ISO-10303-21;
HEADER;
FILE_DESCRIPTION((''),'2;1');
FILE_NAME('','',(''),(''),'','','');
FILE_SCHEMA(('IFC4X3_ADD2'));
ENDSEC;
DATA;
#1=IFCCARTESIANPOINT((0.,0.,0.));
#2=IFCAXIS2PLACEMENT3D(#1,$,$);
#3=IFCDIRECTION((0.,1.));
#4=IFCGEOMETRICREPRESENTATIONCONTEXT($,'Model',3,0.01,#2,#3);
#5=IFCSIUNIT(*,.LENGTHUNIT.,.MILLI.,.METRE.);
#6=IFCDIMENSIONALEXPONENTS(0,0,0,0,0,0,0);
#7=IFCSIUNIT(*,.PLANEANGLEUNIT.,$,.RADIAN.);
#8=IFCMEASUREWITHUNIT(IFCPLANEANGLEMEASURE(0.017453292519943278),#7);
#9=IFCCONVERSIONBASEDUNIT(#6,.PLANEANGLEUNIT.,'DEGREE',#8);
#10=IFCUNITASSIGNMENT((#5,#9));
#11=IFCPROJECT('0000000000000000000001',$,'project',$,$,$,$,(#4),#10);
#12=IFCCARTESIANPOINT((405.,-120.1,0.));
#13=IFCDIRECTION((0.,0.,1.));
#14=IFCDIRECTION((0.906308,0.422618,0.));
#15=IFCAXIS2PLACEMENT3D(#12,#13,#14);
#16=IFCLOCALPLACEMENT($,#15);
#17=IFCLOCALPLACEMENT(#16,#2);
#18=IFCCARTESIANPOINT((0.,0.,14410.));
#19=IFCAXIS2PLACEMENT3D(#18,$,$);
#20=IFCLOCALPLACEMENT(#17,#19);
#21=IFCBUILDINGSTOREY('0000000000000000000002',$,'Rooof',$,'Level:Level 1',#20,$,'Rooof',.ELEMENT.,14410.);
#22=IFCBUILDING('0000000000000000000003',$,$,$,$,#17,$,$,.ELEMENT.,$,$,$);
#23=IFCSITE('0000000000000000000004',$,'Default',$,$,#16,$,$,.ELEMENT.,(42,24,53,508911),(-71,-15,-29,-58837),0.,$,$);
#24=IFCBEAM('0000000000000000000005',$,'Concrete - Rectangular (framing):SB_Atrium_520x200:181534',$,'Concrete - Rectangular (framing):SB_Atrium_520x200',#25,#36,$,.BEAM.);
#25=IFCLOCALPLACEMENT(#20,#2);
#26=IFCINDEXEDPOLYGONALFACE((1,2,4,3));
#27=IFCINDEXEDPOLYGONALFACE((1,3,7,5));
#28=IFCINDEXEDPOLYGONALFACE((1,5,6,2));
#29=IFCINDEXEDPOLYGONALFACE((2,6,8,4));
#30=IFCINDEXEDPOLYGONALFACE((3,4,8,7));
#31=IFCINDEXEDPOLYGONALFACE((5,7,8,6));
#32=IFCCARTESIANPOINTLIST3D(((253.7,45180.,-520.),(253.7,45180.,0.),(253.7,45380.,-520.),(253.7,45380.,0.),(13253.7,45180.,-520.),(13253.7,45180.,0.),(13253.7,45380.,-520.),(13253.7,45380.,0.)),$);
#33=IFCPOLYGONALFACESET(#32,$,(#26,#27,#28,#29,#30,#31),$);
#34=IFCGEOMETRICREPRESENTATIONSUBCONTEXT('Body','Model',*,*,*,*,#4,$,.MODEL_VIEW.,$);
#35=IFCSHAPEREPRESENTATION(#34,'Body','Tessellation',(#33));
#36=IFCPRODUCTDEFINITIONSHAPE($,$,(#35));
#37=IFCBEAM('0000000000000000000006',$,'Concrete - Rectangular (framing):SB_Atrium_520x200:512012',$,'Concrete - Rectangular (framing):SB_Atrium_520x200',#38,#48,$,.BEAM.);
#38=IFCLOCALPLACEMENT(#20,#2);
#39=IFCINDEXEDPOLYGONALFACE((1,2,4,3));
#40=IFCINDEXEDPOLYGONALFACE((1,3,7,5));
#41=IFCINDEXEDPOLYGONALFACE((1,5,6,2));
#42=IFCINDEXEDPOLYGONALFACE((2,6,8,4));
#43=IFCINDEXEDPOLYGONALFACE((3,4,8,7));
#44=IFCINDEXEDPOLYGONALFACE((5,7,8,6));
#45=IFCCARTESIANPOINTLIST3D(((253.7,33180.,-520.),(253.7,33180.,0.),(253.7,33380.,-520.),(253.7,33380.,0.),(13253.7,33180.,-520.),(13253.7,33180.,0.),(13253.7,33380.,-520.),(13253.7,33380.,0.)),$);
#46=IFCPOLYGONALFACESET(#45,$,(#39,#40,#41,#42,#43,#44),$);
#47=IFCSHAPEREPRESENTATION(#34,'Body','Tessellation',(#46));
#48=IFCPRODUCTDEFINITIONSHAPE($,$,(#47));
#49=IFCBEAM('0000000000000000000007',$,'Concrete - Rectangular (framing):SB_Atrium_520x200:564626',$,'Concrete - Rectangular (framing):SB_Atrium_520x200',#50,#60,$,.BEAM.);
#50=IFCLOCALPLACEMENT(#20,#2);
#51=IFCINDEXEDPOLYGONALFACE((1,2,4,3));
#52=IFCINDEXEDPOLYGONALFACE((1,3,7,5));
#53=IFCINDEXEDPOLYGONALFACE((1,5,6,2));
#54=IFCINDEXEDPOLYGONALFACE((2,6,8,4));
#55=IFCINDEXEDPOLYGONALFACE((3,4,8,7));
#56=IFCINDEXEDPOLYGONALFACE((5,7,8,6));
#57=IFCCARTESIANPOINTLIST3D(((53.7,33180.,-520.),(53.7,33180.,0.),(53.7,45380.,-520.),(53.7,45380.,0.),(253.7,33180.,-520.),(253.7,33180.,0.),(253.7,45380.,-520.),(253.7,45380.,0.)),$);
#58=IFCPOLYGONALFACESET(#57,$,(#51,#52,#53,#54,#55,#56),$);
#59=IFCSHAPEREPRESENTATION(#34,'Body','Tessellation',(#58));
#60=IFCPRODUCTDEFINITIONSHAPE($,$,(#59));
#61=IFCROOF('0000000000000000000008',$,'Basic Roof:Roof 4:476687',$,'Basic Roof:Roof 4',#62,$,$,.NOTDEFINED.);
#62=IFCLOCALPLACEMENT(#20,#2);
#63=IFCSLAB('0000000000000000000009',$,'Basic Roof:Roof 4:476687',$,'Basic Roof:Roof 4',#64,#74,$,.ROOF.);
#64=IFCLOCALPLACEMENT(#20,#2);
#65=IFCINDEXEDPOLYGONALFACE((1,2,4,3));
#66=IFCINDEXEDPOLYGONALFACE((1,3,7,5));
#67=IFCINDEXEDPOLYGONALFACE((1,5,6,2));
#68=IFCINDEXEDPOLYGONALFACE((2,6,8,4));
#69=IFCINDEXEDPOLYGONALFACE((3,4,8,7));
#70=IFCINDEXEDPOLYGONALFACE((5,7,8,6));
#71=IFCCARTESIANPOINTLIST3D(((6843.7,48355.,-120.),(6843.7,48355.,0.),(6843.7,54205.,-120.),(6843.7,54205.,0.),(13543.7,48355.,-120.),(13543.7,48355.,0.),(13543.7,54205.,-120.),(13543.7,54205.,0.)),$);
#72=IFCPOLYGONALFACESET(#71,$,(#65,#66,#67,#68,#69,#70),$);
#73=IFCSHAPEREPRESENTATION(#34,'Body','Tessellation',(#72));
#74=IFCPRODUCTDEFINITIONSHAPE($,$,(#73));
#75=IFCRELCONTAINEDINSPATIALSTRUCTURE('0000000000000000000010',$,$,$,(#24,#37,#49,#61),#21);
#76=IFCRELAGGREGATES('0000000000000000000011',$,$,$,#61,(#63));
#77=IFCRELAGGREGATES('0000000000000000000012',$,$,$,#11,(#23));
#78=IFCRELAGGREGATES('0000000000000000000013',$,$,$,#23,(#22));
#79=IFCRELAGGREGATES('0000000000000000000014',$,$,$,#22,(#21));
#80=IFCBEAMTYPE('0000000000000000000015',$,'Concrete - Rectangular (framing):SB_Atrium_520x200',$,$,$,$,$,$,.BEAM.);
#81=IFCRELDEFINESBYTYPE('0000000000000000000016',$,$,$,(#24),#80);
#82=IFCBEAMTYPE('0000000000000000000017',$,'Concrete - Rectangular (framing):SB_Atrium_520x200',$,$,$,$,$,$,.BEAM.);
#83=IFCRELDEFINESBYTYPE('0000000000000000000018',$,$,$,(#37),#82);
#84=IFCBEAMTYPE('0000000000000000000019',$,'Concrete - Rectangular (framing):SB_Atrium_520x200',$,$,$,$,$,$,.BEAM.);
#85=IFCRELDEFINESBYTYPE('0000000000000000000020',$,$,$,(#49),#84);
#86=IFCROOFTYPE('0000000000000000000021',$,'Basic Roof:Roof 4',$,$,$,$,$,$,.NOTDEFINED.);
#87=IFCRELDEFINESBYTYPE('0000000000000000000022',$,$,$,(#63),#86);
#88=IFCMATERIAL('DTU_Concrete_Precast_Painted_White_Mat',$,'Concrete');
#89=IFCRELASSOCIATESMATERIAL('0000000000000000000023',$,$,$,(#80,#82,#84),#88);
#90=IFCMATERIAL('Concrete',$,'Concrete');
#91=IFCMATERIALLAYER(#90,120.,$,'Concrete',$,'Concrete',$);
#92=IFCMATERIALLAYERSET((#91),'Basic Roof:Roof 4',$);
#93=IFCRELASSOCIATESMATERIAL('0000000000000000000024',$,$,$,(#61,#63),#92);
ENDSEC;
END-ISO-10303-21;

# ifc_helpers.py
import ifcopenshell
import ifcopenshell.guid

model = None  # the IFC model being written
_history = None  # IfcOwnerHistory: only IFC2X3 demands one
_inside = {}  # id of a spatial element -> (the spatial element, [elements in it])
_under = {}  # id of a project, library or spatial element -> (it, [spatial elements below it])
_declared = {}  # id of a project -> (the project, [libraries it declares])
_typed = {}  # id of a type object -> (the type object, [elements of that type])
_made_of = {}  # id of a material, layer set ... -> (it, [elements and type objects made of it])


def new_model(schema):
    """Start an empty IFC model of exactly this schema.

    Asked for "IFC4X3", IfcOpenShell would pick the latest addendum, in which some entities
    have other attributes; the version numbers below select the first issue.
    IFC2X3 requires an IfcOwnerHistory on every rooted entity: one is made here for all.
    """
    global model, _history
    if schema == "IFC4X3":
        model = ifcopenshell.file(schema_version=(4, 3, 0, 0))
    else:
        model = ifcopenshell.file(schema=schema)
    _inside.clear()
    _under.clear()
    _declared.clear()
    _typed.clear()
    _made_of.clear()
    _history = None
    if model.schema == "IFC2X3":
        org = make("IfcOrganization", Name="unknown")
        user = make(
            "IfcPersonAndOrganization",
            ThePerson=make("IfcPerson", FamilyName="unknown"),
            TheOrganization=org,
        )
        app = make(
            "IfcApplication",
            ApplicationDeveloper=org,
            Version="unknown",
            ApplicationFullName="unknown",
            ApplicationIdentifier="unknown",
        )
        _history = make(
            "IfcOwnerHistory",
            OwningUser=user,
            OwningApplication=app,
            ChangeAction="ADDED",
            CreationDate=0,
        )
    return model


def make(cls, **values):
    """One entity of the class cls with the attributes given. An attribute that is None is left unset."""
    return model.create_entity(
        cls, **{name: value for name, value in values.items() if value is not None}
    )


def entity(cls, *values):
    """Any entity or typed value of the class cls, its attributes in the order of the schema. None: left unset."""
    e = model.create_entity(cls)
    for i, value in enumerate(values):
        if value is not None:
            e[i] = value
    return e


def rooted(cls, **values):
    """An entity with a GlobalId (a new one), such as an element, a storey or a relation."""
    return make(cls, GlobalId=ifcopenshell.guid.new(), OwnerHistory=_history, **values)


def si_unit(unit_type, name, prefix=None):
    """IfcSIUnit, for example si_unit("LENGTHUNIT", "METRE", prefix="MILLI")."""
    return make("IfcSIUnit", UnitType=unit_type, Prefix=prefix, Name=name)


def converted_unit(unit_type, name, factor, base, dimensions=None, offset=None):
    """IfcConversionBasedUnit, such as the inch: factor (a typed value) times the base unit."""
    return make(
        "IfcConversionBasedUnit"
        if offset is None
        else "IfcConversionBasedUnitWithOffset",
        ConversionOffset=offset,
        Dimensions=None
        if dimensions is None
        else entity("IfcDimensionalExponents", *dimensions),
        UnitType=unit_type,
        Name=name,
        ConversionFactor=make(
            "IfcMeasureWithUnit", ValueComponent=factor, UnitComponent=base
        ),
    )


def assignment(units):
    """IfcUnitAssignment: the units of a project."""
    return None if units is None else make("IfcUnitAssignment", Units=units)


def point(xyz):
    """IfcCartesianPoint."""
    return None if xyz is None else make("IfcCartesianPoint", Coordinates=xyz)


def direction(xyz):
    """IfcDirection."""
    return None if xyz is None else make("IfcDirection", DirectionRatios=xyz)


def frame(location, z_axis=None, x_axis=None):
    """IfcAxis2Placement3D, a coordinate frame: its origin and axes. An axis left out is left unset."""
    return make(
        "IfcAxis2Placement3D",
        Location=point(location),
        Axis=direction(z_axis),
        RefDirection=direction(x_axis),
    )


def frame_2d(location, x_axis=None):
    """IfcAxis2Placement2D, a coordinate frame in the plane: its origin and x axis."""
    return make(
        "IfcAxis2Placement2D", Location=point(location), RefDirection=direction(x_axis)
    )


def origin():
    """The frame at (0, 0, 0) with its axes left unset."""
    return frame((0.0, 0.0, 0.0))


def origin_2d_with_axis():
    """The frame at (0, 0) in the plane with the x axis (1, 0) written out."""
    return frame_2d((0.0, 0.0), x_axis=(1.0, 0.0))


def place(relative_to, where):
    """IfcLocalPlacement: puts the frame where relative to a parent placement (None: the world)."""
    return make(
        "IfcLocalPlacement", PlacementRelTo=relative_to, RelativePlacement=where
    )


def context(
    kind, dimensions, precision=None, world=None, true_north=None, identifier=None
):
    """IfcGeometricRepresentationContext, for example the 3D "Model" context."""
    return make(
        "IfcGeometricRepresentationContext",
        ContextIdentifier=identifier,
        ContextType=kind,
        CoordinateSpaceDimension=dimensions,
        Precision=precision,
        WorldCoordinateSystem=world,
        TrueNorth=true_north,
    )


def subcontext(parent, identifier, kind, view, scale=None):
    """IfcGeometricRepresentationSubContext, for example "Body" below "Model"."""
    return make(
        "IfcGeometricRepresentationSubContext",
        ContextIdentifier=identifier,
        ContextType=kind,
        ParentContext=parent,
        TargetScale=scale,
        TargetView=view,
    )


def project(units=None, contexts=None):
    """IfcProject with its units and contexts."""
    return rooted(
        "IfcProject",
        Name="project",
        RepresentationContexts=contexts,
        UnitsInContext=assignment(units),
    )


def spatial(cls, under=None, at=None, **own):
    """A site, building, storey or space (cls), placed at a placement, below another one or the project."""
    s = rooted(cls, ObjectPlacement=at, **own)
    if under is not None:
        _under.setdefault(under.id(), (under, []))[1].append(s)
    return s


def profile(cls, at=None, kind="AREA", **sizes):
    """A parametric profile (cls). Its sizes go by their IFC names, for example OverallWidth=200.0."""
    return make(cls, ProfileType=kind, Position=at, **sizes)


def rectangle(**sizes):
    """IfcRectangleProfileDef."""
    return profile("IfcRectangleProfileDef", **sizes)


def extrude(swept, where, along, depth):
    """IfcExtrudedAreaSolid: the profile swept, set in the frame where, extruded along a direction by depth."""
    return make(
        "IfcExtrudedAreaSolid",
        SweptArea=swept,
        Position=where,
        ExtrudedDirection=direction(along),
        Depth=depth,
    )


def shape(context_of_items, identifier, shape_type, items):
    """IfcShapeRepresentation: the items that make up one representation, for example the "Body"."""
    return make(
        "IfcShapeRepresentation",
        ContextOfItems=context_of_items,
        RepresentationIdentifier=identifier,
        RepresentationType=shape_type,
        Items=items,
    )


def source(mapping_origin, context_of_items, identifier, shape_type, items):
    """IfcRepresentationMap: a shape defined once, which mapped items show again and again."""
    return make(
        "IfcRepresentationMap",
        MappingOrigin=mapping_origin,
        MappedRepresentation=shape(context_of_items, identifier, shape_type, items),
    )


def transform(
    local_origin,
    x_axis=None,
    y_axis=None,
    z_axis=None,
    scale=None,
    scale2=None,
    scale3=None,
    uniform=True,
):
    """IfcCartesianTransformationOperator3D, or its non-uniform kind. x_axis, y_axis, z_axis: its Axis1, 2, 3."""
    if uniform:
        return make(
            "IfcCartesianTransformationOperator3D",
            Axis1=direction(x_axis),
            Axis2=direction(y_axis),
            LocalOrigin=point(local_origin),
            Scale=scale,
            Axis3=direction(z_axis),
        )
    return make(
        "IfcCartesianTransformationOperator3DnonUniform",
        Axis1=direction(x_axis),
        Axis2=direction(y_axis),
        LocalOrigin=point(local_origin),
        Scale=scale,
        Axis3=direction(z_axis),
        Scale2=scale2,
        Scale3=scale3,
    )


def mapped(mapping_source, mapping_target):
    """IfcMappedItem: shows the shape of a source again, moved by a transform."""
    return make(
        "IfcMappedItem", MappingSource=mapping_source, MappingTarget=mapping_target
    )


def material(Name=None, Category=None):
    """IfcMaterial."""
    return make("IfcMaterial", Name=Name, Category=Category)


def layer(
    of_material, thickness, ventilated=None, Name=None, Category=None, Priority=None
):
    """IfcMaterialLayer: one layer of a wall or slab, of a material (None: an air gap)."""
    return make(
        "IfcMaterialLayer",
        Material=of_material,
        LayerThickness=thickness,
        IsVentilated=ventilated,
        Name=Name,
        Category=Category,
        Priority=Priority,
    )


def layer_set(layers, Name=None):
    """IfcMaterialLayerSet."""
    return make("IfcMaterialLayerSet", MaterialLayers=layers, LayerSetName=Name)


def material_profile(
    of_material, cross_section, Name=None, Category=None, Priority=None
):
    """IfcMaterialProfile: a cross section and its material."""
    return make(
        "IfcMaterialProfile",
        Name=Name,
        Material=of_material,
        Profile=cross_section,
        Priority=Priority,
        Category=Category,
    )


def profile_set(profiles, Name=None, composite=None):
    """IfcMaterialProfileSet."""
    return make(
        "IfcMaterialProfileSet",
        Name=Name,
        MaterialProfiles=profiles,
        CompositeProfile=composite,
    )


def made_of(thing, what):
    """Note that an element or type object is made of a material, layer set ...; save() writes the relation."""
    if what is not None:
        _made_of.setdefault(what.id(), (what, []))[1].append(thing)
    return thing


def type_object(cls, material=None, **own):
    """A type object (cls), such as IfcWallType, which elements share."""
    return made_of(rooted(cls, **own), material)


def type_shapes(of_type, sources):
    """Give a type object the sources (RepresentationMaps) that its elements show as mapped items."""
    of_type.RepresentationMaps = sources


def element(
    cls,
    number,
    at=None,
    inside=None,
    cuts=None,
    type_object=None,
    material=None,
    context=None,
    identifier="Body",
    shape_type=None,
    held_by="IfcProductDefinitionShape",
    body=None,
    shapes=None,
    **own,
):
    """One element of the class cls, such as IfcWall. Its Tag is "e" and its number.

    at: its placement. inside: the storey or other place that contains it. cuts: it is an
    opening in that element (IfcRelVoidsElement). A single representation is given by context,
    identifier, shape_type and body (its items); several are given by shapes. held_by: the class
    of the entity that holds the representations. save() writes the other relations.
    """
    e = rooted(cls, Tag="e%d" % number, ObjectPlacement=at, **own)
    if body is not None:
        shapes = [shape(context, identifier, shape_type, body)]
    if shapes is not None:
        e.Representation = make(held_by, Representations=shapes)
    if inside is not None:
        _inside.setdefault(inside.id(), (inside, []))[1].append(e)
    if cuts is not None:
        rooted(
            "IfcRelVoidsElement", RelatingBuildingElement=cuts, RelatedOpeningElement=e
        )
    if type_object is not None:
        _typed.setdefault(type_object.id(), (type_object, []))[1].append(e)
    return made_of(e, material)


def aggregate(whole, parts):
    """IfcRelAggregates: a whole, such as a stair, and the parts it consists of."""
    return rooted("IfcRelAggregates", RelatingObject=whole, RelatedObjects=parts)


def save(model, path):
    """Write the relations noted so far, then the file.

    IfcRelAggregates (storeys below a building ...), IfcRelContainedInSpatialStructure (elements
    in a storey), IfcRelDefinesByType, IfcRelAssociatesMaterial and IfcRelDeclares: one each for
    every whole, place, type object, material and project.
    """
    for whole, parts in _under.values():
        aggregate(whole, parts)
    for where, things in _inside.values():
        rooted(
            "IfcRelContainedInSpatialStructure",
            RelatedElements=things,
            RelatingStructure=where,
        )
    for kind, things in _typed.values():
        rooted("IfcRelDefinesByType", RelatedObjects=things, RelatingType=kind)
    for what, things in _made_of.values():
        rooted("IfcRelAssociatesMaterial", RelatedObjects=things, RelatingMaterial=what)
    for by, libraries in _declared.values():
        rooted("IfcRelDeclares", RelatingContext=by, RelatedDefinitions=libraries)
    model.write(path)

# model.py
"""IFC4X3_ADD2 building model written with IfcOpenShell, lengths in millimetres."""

from ifc_helpers import new_model, entity, si_unit, converted_unit, direction, frame, frame_2d, origin, origin_2d_with_axis, place, context, subcontext, project, spatial, rectangle, extrude, source, transform, mapped, material, layer, layer_set, material_profile, profile_set, type_object, type_shapes, element, aggregate, save


model = new_model("IFC4X3_ADD2")

# Units and contexts
model_context = context("Model", 3, precision=0.01, world=origin(), true_north=direction((0.0, 1.0)))
body_context = subcontext(model_context, "Body", "Model", "MODEL_VIEW")
ifc_project = project(units=[si_unit("LENGTHUNIT", "METRE", prefix="MILLI"), converted_unit("PLANEANGLEUNIT", "DEGREE", entity("IfcPlaneAngleMeasure", 0.017453292519943278), si_unit("PLANEANGLEUNIT", "RADIAN"), dimensions=[0, 0, 0, 0, 0, 0, 0])], contexts=[model_context])

# Site, building, storey
site_placement = place(None, frame((405.0, -120.1, 0.0), z_axis=(0.0, 0.0, 1.0), x_axis=(0.906308, 0.422618, 0.0)))
site = spatial("IfcSite", under=ifc_project, at=site_placement, Name="Default", CompositionType="ELEMENT", RefLatitude=(42, 24, 53, 508911), RefLongitude=(-71, -15, -29, -58837), RefElevation=0.0)
building_placement = place(site_placement, origin())
building = spatial("IfcBuilding", under=site, at=building_placement, CompositionType="ELEMENT")
storey_placement = place(building_placement, frame((0.0, 0.0, 14410.0)))
storey = spatial("IfcBuildingStorey", under=building, at=storey_placement, Name="Rooof", ObjectType="Level:Level 1", LongName="Rooof", CompositionType="ELEMENT", Elevation=14410.0)

# Beams
ifc_material_1 = material(Name="DTU_Concrete_Precast_Painted_White_Mat", Category="Concrete")
ifc_material_profile = material_profile(ifc_material_1, rectangle(XDim=13000.0, YDim=200.0, at=origin_2d_with_axis()), Name="SB_Atrium_520x200")
ifc_profile_set = profile_set([ifc_material_profile], Name="SB_Atrium_520x200")
beam_type_1 = type_object("IfcBeamType", Name="Concrete - Rectangular (framing):SB_Atrium_520x200", PredefinedType="BEAM", material=ifc_profile_set)
shared_shape_1 = source(origin(), body_context, "Body", "SweptSolid", [
    extrude(rectangle(XDim=13000.0, YDim=200.0, at=origin_2d_with_axis()), frame((0.0, 0.0, -260.0), z_axis=(0.0, 0.0, 1.0), x_axis=(-1.0, 0.0, 0.0)), (0.0, 0.0, 1.0), 520.0),
])
type_shapes(beam_type_1, [shared_shape_1])
beam_1_placement = place(storey_placement, frame((6753.7, 45280.0, -260.0)))
element("IfcBeam", 1, at=beam_1_placement, inside=storey, type_object=beam_type_1, Name="Concrete - Rectangular (framing):SB_Atrium_520x200:181534", ObjectType="Concrete - Rectangular (framing):SB_Atrium_520x200", PredefinedType="BEAM", context=body_context, shape_type="MappedRepresentation", body=[
    mapped(shared_shape_1, transform((0.0, 0.0, 0.0), scale=1.0)),
])
beam_type_2 = type_object("IfcBeamType", Name="Concrete - Rectangular (framing):SB_Atrium_520x200", PredefinedType="BEAM", material=ifc_profile_set)
shared_shape_2 = source(origin(), body_context, "Body", "SweptSolid", [
    extrude(rectangle(XDim=13000.0, YDim=200.0, at=origin_2d_with_axis()), frame((-60.0, 0.0, -260.0), z_axis=(0.0, 0.0, 1.0), x_axis=(-1.0, 0.0, 0.0)), (0.0, 0.0, 1.0), 520.0),
])
type_shapes(beam_type_2, [shared_shape_2])
beam_2_placement = place(storey_placement, frame((6813.7, 33280.0, -260.0)))
element("IfcBeam", 2, at=beam_2_placement, inside=storey, type_object=beam_type_2, Name="Concrete - Rectangular (framing):SB_Atrium_520x200:512012", ObjectType="Concrete - Rectangular (framing):SB_Atrium_520x200", PredefinedType="BEAM", context=body_context, shape_type="MappedRepresentation", body=[
    mapped(shared_shape_2, transform((0.0, 0.0, 0.0), scale=1.0)),
])
beam_type_3 = type_object("IfcBeamType", Name="Concrete - Rectangular (framing):SB_Atrium_520x200", PredefinedType="BEAM", material=ifc_profile_set)
shared_shape_3 = source(origin(), body_context, "Body", "SweptSolid", [
    extrude(rectangle(XDim=12200.0, YDim=200.0, at=origin_2d_with_axis()), frame((0.0, 0.0, -260.0), z_axis=(0.0, 0.0, 1.0), x_axis=(-1.0, 0.0, 0.0)), (0.0, 0.0, 1.0), 520.0),
])
type_shapes(beam_type_3, [shared_shape_3])
beam_3_placement = place(storey_placement, frame((153.7, 39280.0, -260.0), z_axis=(0.0, 0.0, 1.0), x_axis=(0.0, 1.0, 0.0)))
element("IfcBeam", 3, at=beam_3_placement, inside=storey, type_object=beam_type_3, Name="Concrete - Rectangular (framing):SB_Atrium_520x200:564626", ObjectType="Concrete - Rectangular (framing):SB_Atrium_520x200", PredefinedType="BEAM", context=body_context, shape_type="MappedRepresentation", body=[
    mapped(shared_shape_3, transform((0.0, 0.0, 0.0), scale=1.0)),
])

# Roof, slab
ifc_material_2 = material(Name="Concrete", Category="Concrete")
ifc_layer = layer(ifc_material_2, 120.0, Name="Concrete", Category="Concrete")
ifc_layer_set = layer_set([ifc_layer], Name="Basic Roof:Roof 4")
roof_placement = place(storey_placement, frame((6843.7, 48355.0, -120.0)))
roof = element("IfcRoof", 4, at=roof_placement, inside=storey, material=ifc_layer_set, Name="Basic Roof:Roof 4:476687", ObjectType="Basic Roof:Roof 4", PredefinedType="NOTDEFINED")
roof_type = type_object("IfcRoofType", Name="Basic Roof:Roof 4", PredefinedType="NOTDEFINED")
slab_placement = place(roof_placement, origin())
slab = element("IfcSlab", 5, at=slab_placement, type_object=roof_type, material=ifc_layer_set, Name="Basic Roof:Roof 4:476687", ObjectType="Basic Roof:Roof 4", PredefinedType="ROOF", context=body_context, shape_type="SweptSolid", body=[
    extrude(rectangle(XDim=6700.0, YDim=5850.0, at=frame_2d((0.0, 0.0), x_axis=(-1.0, 0.0))), frame((3350.0, 2925.0, 0.0)), (0.0, 0.0, 1.0), 120.0),
])
aggregate(roof, [slab])

save(model, "model.ifc")
